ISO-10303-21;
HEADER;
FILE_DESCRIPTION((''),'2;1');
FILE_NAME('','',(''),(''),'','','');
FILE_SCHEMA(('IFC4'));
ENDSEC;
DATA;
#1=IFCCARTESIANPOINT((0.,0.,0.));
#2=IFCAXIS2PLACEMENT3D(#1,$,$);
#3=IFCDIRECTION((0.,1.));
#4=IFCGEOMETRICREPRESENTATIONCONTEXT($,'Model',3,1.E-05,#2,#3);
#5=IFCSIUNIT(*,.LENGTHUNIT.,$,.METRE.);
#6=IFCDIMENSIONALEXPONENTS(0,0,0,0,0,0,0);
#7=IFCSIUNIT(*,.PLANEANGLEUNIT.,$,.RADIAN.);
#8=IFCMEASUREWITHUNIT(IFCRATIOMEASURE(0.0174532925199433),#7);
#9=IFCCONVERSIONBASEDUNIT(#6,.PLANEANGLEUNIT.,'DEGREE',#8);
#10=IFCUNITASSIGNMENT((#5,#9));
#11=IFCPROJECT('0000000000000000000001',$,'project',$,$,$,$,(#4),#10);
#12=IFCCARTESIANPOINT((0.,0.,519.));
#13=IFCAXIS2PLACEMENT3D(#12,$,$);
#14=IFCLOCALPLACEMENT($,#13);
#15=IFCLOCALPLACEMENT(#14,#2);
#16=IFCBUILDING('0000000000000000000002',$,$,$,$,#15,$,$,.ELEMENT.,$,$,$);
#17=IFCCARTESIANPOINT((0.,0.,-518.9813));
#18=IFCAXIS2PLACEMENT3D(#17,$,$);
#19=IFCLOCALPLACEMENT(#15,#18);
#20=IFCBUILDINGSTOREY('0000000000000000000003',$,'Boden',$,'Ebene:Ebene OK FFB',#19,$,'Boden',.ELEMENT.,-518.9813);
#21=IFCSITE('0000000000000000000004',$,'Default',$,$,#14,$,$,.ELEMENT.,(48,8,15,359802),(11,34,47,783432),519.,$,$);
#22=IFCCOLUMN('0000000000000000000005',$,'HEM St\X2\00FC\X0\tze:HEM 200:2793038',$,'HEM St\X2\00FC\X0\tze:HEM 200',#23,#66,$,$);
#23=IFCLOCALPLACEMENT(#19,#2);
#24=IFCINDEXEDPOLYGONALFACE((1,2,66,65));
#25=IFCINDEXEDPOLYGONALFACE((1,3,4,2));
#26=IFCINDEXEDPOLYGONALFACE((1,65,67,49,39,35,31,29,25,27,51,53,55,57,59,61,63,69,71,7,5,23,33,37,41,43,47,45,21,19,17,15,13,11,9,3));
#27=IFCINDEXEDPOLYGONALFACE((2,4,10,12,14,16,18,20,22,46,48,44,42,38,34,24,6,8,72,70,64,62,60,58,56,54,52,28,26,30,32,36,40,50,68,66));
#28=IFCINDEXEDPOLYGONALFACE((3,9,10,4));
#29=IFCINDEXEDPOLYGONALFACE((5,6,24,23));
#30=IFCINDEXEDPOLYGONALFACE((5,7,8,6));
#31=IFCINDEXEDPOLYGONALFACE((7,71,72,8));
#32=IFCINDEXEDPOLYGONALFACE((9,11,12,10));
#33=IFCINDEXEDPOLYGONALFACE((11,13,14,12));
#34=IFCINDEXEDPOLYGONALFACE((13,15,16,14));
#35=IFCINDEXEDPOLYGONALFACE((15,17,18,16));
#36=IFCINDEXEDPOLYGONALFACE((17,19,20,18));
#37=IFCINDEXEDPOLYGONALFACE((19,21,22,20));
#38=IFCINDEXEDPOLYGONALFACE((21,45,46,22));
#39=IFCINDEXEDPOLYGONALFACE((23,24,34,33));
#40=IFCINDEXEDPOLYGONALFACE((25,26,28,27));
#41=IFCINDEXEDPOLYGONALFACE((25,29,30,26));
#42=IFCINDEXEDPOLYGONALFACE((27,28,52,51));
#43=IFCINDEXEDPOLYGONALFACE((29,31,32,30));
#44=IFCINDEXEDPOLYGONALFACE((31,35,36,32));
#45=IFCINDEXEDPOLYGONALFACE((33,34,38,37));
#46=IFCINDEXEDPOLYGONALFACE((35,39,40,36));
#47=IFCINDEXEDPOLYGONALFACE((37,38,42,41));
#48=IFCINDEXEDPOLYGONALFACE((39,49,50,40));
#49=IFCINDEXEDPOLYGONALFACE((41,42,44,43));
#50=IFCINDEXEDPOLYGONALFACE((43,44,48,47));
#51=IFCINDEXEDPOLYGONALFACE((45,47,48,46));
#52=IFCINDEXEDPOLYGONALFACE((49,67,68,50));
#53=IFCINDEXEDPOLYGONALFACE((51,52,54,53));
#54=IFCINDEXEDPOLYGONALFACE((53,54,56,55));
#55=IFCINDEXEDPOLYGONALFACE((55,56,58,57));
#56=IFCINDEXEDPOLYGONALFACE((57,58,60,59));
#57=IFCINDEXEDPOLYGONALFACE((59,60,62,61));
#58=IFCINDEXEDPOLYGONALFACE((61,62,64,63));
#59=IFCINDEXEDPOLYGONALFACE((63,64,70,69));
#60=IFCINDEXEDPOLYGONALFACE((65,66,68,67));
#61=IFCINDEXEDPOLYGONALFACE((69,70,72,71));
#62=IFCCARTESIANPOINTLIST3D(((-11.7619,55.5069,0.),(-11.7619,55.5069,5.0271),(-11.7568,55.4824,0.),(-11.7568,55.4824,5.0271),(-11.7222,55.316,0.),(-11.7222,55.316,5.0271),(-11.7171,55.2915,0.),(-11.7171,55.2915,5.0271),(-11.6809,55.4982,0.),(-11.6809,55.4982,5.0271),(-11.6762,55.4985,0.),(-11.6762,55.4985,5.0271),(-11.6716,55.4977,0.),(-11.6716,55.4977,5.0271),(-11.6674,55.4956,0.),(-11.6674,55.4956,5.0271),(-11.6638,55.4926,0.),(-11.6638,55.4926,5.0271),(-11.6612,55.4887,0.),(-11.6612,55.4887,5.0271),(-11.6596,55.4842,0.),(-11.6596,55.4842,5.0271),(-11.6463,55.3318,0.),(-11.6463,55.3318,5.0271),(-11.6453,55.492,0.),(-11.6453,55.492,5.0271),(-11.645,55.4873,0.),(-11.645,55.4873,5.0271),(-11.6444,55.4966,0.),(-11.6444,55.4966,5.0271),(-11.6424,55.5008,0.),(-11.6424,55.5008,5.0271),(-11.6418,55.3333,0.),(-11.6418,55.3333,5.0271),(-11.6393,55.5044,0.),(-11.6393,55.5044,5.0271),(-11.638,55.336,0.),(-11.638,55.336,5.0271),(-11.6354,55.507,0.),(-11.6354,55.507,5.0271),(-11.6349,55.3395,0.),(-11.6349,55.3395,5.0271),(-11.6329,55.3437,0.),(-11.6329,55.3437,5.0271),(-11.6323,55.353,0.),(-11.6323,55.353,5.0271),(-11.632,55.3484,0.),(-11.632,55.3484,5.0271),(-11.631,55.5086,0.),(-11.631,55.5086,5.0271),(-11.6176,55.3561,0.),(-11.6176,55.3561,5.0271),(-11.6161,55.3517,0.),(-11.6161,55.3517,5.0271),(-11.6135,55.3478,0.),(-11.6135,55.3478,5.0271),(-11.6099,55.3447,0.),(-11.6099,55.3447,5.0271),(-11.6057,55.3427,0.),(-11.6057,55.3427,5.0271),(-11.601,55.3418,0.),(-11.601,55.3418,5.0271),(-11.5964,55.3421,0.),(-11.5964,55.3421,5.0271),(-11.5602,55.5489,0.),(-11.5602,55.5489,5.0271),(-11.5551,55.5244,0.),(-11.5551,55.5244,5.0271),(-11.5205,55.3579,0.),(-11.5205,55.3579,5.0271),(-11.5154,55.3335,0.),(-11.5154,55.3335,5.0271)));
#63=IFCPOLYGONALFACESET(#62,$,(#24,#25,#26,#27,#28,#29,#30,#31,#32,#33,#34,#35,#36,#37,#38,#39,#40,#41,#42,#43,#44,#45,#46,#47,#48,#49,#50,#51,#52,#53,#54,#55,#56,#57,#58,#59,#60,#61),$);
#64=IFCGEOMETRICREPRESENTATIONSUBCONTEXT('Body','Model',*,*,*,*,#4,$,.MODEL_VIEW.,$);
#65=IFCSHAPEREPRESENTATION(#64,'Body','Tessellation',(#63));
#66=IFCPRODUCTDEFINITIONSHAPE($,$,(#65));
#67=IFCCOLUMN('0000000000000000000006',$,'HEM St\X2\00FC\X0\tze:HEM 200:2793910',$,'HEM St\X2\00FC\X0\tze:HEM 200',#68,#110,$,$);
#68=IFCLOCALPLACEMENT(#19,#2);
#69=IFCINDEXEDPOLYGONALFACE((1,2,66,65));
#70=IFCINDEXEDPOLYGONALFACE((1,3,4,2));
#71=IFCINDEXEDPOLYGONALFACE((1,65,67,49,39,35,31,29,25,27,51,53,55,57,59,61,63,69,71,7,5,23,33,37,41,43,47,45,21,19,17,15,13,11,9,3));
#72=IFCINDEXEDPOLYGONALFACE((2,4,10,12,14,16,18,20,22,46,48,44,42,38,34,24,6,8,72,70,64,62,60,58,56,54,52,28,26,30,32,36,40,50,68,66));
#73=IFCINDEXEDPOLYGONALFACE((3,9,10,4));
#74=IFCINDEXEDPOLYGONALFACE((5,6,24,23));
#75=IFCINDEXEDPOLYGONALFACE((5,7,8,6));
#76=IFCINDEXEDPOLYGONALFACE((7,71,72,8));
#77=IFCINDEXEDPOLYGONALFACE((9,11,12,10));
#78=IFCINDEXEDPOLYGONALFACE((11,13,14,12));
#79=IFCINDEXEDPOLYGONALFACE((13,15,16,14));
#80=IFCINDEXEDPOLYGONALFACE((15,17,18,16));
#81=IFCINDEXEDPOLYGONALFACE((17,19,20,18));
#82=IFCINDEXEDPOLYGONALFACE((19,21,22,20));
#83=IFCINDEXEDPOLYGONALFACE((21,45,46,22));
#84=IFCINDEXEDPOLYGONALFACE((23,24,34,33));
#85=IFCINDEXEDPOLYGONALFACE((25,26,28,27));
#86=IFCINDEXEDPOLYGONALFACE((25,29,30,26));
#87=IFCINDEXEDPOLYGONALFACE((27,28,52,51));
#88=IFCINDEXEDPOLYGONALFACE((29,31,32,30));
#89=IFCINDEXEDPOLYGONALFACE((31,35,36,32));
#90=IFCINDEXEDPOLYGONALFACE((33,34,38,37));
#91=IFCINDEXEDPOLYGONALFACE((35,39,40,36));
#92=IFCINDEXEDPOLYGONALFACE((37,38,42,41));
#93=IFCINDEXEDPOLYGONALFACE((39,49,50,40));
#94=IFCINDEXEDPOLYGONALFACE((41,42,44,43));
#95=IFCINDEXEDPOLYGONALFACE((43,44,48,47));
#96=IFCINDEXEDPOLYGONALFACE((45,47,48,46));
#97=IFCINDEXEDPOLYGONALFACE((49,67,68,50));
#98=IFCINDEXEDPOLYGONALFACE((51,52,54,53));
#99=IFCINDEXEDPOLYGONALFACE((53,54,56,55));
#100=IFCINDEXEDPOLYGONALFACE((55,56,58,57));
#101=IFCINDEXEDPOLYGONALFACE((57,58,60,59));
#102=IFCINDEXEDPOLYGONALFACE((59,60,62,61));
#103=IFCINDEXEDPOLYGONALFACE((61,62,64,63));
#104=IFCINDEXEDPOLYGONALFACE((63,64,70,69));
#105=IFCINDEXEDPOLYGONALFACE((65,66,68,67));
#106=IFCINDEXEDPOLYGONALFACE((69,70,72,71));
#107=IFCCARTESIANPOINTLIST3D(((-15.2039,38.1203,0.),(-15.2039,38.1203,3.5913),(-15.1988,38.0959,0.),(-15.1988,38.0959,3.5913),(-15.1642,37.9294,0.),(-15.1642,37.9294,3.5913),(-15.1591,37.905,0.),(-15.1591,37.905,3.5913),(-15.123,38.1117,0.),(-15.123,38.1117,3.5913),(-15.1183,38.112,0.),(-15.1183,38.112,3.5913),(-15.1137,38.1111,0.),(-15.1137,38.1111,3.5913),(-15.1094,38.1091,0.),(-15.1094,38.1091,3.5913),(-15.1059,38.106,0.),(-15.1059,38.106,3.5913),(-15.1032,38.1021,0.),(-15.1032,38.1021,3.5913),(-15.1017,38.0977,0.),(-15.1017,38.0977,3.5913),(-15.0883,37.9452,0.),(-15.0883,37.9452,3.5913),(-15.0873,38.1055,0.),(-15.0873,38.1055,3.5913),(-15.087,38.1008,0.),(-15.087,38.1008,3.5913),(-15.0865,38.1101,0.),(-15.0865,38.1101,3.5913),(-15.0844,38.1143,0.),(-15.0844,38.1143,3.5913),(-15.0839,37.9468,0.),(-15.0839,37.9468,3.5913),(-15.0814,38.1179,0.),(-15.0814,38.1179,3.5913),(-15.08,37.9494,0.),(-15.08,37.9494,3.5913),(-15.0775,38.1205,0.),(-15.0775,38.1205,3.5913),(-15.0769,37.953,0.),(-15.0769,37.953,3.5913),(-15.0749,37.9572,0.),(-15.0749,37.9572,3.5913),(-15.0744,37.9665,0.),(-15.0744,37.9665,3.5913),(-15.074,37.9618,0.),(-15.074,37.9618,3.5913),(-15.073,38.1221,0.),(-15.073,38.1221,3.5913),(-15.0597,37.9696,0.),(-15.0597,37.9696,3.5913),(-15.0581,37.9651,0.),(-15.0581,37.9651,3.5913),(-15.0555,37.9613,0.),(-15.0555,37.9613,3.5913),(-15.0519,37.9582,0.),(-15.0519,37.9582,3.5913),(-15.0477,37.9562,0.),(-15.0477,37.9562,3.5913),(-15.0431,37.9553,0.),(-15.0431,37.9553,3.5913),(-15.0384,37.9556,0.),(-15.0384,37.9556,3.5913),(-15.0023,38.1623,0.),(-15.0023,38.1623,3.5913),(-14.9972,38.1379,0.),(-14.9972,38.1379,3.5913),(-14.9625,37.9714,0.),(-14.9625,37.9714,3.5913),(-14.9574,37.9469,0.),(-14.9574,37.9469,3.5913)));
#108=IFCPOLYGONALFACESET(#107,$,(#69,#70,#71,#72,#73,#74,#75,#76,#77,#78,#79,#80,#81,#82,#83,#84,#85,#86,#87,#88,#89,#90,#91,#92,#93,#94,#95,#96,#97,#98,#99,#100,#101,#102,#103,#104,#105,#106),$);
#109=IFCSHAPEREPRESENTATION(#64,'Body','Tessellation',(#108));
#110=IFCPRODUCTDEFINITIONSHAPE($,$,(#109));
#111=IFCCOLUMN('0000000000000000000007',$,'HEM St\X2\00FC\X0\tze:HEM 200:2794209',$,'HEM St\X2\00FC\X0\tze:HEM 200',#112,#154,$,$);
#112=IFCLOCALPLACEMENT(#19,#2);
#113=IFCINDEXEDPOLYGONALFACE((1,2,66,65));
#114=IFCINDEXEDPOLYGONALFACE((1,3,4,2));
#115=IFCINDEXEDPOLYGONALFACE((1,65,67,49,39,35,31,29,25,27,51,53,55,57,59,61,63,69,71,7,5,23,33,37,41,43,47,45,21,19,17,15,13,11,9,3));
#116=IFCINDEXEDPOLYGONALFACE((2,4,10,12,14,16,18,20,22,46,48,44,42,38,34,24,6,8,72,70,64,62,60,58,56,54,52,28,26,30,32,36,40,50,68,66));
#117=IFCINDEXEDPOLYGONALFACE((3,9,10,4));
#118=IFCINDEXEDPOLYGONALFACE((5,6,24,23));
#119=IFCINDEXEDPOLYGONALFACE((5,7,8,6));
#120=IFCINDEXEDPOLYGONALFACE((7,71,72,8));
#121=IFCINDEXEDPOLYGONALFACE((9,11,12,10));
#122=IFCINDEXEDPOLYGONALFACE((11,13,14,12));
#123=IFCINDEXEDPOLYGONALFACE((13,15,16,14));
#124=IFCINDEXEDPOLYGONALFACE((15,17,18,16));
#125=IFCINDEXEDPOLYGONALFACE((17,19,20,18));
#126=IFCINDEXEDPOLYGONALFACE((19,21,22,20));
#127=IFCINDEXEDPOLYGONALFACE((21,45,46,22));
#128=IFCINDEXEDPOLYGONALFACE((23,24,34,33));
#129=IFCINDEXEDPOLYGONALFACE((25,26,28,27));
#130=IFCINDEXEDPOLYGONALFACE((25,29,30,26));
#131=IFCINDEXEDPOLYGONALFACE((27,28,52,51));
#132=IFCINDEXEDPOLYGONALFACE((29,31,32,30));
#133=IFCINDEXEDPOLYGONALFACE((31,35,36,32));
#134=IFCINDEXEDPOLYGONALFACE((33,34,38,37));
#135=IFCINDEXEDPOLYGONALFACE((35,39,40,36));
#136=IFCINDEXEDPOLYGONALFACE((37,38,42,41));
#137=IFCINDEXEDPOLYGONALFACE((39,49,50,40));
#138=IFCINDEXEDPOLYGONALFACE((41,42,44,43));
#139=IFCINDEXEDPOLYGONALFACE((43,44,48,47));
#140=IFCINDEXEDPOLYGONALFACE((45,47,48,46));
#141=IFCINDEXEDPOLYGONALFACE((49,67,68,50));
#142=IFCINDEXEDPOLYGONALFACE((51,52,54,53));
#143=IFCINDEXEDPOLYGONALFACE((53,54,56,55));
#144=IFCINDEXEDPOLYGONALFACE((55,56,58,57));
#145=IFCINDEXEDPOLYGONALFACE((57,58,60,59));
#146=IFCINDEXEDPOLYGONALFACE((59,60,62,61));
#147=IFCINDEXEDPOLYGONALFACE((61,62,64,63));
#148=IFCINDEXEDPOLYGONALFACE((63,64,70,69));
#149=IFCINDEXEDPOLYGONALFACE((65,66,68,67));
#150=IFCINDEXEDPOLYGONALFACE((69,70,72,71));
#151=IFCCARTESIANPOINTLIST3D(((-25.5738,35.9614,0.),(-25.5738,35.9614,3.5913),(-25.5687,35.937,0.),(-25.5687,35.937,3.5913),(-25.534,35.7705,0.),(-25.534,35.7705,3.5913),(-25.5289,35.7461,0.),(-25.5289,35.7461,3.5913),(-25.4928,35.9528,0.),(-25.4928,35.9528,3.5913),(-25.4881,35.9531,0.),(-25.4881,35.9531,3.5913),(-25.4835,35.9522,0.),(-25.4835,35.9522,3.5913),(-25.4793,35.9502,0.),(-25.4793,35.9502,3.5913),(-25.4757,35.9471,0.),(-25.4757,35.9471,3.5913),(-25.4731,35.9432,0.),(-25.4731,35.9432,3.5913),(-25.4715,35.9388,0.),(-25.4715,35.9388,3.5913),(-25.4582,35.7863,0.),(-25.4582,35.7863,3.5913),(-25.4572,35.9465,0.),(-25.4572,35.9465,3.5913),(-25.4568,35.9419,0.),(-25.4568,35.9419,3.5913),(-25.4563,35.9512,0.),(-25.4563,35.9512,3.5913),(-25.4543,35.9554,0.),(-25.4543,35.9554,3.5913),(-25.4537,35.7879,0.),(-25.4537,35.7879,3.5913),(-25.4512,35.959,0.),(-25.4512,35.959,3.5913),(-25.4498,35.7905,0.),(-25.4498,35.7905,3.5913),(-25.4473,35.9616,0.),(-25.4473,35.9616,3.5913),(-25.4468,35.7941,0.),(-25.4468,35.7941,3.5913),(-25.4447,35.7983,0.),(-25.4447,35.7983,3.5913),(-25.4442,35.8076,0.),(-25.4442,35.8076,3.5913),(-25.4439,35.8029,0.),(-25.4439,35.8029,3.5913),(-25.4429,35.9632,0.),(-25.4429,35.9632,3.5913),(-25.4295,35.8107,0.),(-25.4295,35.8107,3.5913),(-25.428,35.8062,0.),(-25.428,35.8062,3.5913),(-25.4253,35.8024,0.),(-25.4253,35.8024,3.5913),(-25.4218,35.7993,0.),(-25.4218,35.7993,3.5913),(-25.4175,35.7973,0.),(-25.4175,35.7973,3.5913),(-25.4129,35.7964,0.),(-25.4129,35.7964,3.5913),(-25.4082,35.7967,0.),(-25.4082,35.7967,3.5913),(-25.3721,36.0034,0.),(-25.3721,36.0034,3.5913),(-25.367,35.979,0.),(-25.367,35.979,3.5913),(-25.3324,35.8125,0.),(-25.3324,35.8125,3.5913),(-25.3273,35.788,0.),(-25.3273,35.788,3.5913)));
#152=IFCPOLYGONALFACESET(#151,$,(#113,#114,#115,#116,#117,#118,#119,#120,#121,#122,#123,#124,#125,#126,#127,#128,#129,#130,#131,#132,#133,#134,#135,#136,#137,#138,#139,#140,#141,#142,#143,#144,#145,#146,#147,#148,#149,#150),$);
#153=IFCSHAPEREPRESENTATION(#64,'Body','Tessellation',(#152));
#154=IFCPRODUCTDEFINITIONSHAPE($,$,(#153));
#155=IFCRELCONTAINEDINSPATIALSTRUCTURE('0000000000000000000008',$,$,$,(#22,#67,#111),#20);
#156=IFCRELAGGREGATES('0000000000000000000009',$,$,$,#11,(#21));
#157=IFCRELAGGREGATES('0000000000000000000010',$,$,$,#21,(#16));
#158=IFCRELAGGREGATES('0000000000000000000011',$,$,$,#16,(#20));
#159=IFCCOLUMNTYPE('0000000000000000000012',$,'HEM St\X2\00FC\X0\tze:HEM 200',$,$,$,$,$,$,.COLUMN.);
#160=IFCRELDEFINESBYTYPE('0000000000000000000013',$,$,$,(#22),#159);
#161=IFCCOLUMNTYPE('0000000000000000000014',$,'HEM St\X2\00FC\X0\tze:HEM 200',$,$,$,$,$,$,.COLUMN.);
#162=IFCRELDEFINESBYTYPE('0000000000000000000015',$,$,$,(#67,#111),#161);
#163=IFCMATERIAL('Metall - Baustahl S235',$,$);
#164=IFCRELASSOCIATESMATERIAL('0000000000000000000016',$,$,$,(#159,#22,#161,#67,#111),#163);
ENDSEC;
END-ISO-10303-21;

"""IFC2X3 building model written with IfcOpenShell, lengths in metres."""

from ifc_helpers import new_model, entity, si_unit, converted_unit, direction, frame, frame_2d, origin, place, context, subcontext, project, spatial, polyline, circle_curve, parameter, trimmed, segment, composite_curve, outline, extrude, source, transform, mapped, material, type_object, type_shapes, element, save


model = new_model("IFC2X3")

# Units and contexts
model_context = context("Model", 3, precision=1e-05, world=origin(), true_north=direction((0.0, 1.0)))
body_context = subcontext(model_context, "Body", "Model", "MODEL_VIEW")
ifc_project = project(units=[si_unit("LENGTHUNIT", "METRE"), converted_unit("PLANEANGLEUNIT", "DEGREE", entity("IfcRatioMeasure", 0.0174532925199433), si_unit("PLANEANGLEUNIT", "RADIAN"), dimensions=[0, 0, 0, 0, 0, 0, 0])], contexts=[model_context])

# Site, building, storey
site_placement = place(None, frame((0.0, 0.0, 519.0)))
site = spatial("IfcSite", under=ifc_project, at=site_placement, Name="Default", CompositionType="ELEMENT", RefLatitude=(48, 8, 15, 359802), RefLongitude=(11, 34, 47, 783432), RefElevation=519.0)
building_placement = place(site_placement, origin())
building = spatial("IfcBuilding", under=site, at=building_placement, CompositionType="ELEMENT")
storey_placement = place(building_placement, frame((0.0, 0.0, -518.9813)))
storey = spatial("IfcBuildingStorey", under=building, at=storey_placement, Name="Boden", ObjectType="Ebene:Ebene OK FFB", LongName="Boden", CompositionType="ELEMENT", Elevation=-518.9813)

# Columns
ifc_material = material(Name="Metall - Baustahl S235")
column_type_1 = type_object("IfcColumnType", Name="HEM Stütze:HEM 200", PredefinedType="COLUMN", material=ifc_material)
shared_shape_1 = source(origin(), body_context, "Body", "SweptSolid", [
    extrude(outline(composite_curve([segment(polyline([(0.085, -0.103), (0.11, -0.103)]), True, "CONTINUOUS"), segment(polyline([(0.11, -0.103), (0.11, 0.103)]), True, "CONTINUOUS"), segment(polyline([(0.11, 0.103), (0.085, 0.103)]), True, "CONTINUOUS"), segment(polyline([(0.085, 0.103), (0.085, 0.0255)]), True, "CONTINUOUS"), segment(trimmed(circle_curve(frame_2d((0.067, 0.0255), x_axis=(1.0, 0.0)), 0.018), [parameter(270.0)], [parameter(0.0)], True, "PARAMETER"), False, "CONTINUOUS"), segment(polyline([(0.067, 0.0075), (-0.067, 0.0075)]), True, "CONTINUOUS"), segment(trimmed(circle_curve(frame_2d((-0.067, 0.0255), x_axis=(0.0, -1.0)), 0.018), [parameter(270.0)], [parameter(0.0)], True, "PARAMETER"), False, "CONTINUOUS"), segment(polyline([(-0.085, 0.0255), (-0.085, 0.103)]), True, "CONTINUOUS"), segment(polyline([(-0.085, 0.103), (-0.11, 0.103)]), True, "CONTINUOUS"), segment(polyline([(-0.11, 0.103), (-0.11, -0.103)]), True, "CONTINUOUS"), segment(polyline([(-0.11, -0.103), (-0.085, -0.103)]), True, "CONTINUOUS"), segment(polyline([(-0.085, -0.103), (-0.085, -0.0255)]), True, "CONTINUOUS"), segment(trimmed(circle_curve(frame_2d((-0.067, -0.0255), x_axis=(-1.0, 0.0)), 0.018), [parameter(270.0)], [parameter(0.0)], True, "PARAMETER"), False, "CONTINUOUS"), segment(polyline([(-0.067, -0.0075), (0.067, -0.0075)]), True, "CONTINUOUS"), segment(trimmed(circle_curve(frame_2d((0.067, -0.0255), x_axis=(0.0, 1.0)), 0.018), [parameter(270.0)], [parameter(0.0)], True, "PARAMETER"), False, "CONTINUOUS"), segment(polyline([(0.085, -0.0255), (0.085, -0.103)]), True, "CONTINUOUS")], self_intersect=False)), frame((-11.6386, 55.4202, -518.9813), z_axis=(0.0, 0.0, 1.0), x_axis=(-0.20382, 0.979008, 0.0)), (0.0, 0.0, 1.0), 5.0271),
])
type_shapes(column_type_1, [shared_shape_1])
column_1_placement = place(storey_placement, frame((0.0, 0.0, 518.9813)))
element("IfcColumn", 1, at=column_1_placement, inside=storey, type_object=column_type_1, material=ifc_material, Name="HEM Stütze:HEM 200:2793038", ObjectType="HEM Stütze:HEM 200", context=body_context, shape_type="MappedRepresentation", body=[
    mapped(shared_shape_1, transform((0.0, 0.0, 0.0), scale=1.0)),
])
column_type_2 = type_object("IfcColumnType", Name="HEM Stütze:HEM 200", PredefinedType="COLUMN", material=ifc_material)
shared_shape_2 = source(origin(), body_context, "Body", "SweptSolid", [
    extrude(outline(composite_curve([segment(polyline([(0.085, -0.103), (0.11, -0.103)]), True, "CONTINUOUS"), segment(polyline([(0.11, -0.103), (0.11, 0.103)]), True, "CONTINUOUS"), segment(polyline([(0.11, 0.103), (0.085, 0.103)]), True, "CONTINUOUS"), segment(polyline([(0.085, 0.103), (0.085, 0.0255)]), True, "CONTINUOUS"), segment(trimmed(circle_curve(frame_2d((0.067, 0.0255), x_axis=(1.0, 0.0)), 0.018), [parameter(270.0)], [parameter(0.0)], True, "PARAMETER"), False, "CONTINUOUS"), segment(polyline([(0.067, 0.0075), (-0.067, 0.0075)]), True, "CONTINUOUS"), segment(trimmed(circle_curve(frame_2d((-0.067, 0.0255), x_axis=(0.0, -1.0)), 0.018), [parameter(270.0)], [parameter(0.0)], True, "PARAMETER"), False, "CONTINUOUS"), segment(polyline([(-0.085, 0.0255), (-0.085, 0.103)]), True, "CONTINUOUS"), segment(polyline([(-0.085, 0.103), (-0.11, 0.103)]), True, "CONTINUOUS"), segment(polyline([(-0.11, 0.103), (-0.11, -0.103)]), True, "CONTINUOUS"), segment(polyline([(-0.11, -0.103), (-0.085, -0.103)]), True, "CONTINUOUS"), segment(polyline([(-0.085, -0.103), (-0.085, -0.0255)]), True, "CONTINUOUS"), segment(trimmed(circle_curve(frame_2d((-0.067, -0.0255), x_axis=(-1.0, 0.0)), 0.018), [parameter(270.0)], [parameter(0.0)], True, "PARAMETER"), False, "CONTINUOUS"), segment(polyline([(-0.067, -0.0075), (0.067, -0.0075)]), True, "CONTINUOUS"), segment(trimmed(circle_curve(frame_2d((0.067, -0.0255), x_axis=(0.0, 1.0)), 0.018), [parameter(270.0)], [parameter(0.0)], True, "PARAMETER"), False, "CONTINUOUS"), segment(polyline([(0.085, -0.0255), (0.085, -0.103)]), True, "CONTINUOUS")], self_intersect=False)), frame((0.0, 0.0, -518.9813), z_axis=(0.0, 0.0, 1.0), x_axis=(0.0, -1.0, 0.0)), (0.0, 0.0, 1.0), 3.5913),
])
type_shapes(column_type_2, [shared_shape_2])
for number, where, z_axis, x_axis, name in (
    (2, (-15.0807, 38.0336, 518.9813), (0.0, 0.0, 1.0), (0.979008, 0.20382, 0.0), "HEM Stütze:HEM 200:2793910"),
    (3, (-25.4505, 35.8747, 518.9813), (0.0, 0.0, 1.0), (0.979008, 0.20382, 0.0), "HEM Stütze:HEM 200:2794209"),
):
    element("IfcColumn", number, at=place(storey_placement, frame(where, z_axis=z_axis, x_axis=x_axis)), inside=storey, type_object=column_type_2, material=ifc_material, Name=name, ObjectType="HEM Stütze:HEM 200", context=body_context, shape_type="MappedRepresentation", body=[
        mapped(shared_shape_2, transform((0.0, 0.0, 0.0), scale=1.0)),
    ])

save(model, "model.ifc")
